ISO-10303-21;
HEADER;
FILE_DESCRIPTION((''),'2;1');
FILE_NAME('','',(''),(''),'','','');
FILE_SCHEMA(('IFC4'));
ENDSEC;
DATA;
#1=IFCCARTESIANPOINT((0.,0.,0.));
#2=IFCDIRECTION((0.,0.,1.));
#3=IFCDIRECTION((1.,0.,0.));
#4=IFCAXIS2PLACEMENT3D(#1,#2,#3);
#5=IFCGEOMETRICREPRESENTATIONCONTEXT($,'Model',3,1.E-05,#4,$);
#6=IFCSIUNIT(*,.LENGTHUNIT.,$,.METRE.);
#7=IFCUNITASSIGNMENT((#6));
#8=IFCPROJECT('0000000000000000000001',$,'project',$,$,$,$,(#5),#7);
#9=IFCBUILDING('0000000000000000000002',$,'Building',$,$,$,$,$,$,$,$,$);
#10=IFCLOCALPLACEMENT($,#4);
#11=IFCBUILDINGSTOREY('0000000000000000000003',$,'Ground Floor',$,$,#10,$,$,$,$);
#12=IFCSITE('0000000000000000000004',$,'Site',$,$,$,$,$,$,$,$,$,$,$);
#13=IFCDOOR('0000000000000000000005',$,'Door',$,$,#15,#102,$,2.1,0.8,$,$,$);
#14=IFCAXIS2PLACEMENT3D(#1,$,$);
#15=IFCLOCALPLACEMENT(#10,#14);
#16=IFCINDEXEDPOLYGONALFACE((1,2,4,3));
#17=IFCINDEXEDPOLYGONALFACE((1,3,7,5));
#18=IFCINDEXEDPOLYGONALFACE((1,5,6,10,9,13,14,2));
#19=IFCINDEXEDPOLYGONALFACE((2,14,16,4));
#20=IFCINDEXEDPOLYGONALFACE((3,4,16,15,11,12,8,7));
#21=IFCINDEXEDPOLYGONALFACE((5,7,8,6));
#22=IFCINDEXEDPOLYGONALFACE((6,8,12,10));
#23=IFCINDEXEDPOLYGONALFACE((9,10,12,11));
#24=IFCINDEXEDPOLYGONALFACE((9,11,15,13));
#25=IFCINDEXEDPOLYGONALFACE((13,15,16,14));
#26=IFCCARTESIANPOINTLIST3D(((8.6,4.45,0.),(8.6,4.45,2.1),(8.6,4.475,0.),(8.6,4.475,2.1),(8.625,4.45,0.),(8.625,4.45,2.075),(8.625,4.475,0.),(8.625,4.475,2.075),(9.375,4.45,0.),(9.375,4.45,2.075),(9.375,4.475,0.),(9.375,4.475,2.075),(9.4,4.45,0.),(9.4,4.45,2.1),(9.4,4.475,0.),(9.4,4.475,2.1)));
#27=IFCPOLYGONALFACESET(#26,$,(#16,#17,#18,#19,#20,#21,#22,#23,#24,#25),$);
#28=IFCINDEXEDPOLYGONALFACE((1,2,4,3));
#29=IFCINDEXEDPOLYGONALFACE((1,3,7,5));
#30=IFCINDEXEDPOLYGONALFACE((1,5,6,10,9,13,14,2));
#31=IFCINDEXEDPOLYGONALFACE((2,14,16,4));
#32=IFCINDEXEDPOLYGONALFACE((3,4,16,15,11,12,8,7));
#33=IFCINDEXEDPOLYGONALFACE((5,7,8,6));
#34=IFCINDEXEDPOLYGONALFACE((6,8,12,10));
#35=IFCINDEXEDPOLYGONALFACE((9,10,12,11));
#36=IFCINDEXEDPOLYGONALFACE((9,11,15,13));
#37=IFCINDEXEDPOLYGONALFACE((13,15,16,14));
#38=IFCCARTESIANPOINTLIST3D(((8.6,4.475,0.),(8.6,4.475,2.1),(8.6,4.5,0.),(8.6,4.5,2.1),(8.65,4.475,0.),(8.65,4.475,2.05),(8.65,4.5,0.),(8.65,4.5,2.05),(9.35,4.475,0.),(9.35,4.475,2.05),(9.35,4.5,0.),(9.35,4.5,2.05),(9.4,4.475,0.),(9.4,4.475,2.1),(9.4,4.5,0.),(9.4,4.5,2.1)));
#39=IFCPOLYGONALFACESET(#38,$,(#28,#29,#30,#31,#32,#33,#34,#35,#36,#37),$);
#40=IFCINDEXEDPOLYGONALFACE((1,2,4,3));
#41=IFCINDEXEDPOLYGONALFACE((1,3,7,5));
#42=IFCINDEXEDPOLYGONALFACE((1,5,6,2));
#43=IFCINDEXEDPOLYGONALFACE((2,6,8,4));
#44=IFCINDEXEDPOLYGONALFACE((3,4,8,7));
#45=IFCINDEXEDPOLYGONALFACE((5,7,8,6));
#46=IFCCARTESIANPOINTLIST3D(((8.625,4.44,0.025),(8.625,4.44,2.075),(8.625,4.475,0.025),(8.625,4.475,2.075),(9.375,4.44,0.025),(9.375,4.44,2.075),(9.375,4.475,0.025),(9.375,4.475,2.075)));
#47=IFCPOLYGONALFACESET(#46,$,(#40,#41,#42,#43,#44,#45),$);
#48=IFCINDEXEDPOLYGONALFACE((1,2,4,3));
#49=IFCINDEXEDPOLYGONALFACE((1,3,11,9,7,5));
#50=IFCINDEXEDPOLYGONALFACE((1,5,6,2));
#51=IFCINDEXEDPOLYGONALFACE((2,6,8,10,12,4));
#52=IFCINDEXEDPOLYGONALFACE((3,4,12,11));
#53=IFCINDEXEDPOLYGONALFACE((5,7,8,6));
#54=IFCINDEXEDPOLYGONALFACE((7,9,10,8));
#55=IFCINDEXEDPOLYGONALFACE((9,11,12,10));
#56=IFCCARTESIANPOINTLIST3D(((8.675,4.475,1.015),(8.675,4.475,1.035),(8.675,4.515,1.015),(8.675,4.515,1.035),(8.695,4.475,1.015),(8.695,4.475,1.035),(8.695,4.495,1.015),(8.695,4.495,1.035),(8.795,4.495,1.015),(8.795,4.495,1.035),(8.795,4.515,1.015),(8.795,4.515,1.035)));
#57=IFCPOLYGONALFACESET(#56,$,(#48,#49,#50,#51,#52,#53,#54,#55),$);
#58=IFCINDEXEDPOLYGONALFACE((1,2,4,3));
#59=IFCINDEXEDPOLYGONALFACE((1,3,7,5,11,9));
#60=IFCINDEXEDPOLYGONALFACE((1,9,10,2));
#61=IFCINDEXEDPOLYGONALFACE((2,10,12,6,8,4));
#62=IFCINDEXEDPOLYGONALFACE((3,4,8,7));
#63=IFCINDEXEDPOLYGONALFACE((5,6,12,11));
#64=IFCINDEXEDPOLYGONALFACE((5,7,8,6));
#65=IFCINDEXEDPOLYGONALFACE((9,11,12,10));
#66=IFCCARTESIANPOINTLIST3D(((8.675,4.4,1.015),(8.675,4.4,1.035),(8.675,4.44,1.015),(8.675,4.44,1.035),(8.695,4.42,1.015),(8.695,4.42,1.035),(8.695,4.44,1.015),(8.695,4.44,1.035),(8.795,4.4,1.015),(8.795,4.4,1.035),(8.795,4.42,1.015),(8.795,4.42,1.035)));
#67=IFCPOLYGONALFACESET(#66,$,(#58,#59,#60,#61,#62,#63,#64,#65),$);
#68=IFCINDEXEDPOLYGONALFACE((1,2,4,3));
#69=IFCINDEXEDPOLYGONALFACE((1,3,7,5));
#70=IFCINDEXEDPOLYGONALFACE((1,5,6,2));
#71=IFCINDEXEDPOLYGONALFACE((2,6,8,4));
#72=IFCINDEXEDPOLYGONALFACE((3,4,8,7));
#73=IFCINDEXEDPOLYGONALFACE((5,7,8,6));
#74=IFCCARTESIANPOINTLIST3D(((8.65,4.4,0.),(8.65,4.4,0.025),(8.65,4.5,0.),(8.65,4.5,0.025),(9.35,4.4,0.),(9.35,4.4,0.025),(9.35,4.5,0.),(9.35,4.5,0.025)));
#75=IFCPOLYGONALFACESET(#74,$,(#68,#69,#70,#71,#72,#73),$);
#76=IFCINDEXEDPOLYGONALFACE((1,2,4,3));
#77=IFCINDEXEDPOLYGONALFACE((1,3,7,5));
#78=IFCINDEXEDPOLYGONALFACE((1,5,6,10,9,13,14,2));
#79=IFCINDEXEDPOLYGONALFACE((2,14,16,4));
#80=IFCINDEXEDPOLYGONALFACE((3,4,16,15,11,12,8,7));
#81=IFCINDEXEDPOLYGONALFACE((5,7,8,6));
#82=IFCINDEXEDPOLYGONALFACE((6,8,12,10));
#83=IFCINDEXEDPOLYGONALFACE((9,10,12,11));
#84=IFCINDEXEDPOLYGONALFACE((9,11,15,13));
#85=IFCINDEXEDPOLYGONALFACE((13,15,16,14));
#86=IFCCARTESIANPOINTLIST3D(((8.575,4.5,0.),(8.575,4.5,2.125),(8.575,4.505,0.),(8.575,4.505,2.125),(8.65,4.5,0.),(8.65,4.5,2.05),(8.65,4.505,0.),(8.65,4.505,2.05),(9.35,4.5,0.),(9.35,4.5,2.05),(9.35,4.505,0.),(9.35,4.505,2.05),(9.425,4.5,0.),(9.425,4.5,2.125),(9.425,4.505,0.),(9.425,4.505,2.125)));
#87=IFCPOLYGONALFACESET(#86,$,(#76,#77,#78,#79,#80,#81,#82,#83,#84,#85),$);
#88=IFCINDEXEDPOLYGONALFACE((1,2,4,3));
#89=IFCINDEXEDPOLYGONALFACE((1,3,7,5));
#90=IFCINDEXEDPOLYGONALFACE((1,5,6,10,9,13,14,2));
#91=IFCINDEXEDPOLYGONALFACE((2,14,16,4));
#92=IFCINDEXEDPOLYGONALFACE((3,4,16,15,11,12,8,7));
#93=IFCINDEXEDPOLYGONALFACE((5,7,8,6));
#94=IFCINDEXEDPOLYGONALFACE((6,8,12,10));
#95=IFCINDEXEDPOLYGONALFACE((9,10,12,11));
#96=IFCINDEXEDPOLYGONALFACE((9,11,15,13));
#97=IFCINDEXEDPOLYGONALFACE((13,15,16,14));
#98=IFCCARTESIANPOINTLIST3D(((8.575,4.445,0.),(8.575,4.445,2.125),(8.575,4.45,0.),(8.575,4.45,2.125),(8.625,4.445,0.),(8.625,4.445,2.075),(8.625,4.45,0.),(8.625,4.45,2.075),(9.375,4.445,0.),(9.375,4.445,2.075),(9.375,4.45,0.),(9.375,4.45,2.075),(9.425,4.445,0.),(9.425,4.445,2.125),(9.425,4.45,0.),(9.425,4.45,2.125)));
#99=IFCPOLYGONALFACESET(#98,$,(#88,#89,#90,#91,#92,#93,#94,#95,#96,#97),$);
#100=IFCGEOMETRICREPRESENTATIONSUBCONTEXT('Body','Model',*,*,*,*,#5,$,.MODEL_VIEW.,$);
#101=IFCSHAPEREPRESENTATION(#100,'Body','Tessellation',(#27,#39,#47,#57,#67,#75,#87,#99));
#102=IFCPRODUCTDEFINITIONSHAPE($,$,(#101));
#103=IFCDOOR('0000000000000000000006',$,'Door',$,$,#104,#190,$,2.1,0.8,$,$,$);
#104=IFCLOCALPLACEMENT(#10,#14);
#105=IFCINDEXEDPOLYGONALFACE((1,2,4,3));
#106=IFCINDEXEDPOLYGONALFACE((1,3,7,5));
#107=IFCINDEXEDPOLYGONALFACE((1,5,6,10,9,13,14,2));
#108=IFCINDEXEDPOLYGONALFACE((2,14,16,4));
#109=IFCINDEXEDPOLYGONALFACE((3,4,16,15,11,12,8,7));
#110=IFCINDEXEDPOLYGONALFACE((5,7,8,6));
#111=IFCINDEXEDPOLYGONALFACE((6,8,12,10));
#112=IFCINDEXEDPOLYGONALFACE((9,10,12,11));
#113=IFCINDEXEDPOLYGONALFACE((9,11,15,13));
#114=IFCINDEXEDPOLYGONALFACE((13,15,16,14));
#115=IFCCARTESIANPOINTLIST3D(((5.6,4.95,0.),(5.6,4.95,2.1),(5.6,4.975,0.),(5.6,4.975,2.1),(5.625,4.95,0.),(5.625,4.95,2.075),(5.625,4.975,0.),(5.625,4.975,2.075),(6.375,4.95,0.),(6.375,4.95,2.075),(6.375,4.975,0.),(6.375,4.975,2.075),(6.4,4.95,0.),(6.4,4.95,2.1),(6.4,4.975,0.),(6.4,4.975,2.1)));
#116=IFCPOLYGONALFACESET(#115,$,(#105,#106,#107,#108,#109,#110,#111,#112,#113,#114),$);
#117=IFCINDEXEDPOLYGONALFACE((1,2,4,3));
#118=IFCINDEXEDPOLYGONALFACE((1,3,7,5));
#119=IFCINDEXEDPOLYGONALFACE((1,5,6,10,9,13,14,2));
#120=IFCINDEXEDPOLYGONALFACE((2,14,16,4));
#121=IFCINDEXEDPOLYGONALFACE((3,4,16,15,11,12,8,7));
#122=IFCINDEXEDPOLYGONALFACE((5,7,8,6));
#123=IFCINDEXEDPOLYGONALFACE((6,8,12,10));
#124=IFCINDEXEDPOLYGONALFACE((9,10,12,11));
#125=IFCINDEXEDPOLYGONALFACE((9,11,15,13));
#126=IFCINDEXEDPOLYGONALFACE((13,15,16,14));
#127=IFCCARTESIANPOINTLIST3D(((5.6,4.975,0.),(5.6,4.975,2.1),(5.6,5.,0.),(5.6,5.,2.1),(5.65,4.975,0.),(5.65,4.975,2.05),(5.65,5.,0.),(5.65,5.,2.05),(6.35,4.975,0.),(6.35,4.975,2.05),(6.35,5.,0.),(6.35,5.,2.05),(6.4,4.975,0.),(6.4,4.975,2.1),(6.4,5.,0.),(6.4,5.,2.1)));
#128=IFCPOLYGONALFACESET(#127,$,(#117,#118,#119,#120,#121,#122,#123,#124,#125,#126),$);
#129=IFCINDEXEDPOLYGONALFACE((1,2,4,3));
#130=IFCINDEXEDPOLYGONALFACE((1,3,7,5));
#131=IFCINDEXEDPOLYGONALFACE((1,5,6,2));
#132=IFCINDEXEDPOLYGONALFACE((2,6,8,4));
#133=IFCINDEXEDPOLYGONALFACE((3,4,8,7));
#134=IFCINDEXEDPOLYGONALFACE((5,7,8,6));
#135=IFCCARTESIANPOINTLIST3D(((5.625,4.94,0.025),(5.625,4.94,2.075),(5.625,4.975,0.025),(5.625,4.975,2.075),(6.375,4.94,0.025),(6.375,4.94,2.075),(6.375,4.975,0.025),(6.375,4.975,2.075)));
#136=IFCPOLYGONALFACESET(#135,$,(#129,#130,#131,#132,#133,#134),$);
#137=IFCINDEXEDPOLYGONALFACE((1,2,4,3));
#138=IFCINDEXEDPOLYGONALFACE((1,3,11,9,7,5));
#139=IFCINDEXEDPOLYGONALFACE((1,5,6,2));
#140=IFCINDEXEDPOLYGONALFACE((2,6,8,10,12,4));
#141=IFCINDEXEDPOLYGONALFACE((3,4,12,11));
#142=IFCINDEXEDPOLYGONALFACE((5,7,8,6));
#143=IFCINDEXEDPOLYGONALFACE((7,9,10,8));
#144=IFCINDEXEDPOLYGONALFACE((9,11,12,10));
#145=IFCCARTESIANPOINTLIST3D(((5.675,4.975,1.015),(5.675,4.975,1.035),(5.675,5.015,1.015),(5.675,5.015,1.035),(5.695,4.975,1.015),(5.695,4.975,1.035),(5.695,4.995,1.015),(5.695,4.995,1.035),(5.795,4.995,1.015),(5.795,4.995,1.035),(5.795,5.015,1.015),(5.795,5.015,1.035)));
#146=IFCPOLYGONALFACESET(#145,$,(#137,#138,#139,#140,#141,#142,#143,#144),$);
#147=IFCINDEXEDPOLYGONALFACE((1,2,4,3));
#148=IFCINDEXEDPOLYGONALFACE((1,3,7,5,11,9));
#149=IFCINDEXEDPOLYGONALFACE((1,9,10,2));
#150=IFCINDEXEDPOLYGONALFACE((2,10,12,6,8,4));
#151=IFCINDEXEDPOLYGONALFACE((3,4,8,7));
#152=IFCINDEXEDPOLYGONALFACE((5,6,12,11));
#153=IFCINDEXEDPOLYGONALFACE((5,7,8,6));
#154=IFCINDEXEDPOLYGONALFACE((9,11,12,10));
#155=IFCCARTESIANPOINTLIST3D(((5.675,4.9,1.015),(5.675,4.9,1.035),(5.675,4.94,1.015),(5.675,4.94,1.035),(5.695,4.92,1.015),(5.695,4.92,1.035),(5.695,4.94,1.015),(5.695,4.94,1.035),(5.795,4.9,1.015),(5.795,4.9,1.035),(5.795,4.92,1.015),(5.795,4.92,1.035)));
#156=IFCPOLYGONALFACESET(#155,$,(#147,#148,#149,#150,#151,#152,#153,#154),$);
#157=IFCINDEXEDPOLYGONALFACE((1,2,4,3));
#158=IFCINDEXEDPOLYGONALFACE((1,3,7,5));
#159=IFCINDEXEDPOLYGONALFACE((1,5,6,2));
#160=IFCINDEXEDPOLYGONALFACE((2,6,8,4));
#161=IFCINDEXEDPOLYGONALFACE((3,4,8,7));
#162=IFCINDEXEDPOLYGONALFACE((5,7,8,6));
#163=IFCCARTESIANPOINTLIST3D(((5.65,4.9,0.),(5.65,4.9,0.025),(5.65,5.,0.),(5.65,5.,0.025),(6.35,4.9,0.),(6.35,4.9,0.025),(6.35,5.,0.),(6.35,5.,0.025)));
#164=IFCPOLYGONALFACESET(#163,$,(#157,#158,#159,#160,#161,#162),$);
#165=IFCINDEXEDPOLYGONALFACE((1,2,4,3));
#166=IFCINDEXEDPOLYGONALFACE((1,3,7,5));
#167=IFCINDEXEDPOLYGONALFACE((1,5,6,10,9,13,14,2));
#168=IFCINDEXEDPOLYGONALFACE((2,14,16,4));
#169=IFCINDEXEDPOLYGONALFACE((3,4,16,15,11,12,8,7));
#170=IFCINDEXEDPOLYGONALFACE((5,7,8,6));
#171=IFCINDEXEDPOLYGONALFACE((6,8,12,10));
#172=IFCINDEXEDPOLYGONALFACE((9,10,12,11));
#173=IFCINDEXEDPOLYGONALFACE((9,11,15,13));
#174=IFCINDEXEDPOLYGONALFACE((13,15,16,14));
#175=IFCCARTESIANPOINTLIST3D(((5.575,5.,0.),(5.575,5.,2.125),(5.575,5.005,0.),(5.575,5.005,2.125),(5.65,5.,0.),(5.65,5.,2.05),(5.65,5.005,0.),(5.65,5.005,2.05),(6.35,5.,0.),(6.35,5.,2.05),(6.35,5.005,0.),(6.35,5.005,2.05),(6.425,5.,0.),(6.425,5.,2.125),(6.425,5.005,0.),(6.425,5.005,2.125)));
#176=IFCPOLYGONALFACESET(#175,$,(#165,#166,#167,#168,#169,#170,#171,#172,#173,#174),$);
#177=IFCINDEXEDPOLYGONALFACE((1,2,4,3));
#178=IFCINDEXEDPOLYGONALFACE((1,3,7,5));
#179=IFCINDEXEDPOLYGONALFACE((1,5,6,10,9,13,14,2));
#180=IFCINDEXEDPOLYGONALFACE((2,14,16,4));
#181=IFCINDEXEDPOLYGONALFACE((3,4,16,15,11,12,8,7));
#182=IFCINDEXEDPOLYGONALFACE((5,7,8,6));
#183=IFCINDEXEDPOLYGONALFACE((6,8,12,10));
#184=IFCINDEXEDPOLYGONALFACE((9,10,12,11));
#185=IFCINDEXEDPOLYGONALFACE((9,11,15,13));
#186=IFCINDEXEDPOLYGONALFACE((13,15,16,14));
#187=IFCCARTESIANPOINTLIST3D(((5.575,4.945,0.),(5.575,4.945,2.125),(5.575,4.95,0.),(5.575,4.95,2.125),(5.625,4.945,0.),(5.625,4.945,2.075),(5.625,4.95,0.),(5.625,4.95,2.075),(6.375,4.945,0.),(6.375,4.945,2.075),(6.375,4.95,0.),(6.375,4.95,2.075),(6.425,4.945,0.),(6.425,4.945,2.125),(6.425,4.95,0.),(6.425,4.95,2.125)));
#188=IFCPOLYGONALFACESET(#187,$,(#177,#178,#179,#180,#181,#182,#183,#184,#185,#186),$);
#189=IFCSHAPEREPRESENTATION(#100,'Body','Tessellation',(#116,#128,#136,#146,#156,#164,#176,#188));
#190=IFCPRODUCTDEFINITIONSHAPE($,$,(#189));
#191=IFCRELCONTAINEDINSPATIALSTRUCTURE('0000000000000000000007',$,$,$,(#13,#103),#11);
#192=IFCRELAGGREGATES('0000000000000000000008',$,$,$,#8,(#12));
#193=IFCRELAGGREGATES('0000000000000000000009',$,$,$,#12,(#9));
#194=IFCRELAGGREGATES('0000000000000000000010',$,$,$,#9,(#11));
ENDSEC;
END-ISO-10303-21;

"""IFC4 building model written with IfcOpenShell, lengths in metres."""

from ifc_helpers import new_model, si_unit, frame, origin_with_axes, place, context, subcontext, project, spatial, line, indexed_curve, outline, extrude, element, save


model = new_model("IFC4")

# Units and contexts
model_context = context("Model", 3, precision=1e-05, world=origin_with_axes())
body_context = subcontext(model_context, "Body", "Model", "MODEL_VIEW")
ifc_project = project(units=[si_unit("LENGTHUNIT", "METRE")], contexts=[model_context])

# Site, building, storey
site = spatial("IfcSite", under=ifc_project, Name="Site")
building = spatial("IfcBuilding", under=site, Name="Building")
storey_placement = place(None, origin_with_axes())
storey = spatial("IfcBuildingStorey", under=building, at=storey_placement, Name="Ground Floor")

# Doors
door_1_placement = place(storey_placement, frame((9.4, 4.5, 0.0), z_axis=(0.0, 0.0, 1.0), x_axis=(-1.0, 0.0, 0.0)))
element("IfcDoor", 1, at=door_1_placement, inside=storey, Name="Door", OverallHeight=2.1, OverallWidth=0.8, context=body_context, shape_type="SweptSolid", body=[
    extrude(outline(indexed_curve([(0.0, 0.0), (0.0, 2.1), (0.8, 2.1), (0.8, 0.0), (0.775, 0.0), (0.775, 2.075), (0.025, 2.075), (0.025, 0.0)], segments=[line(1, 2, 3, 4, 5, 6, 7, 8, 1)])), frame((0.0, 0.025, 0.0), z_axis=(0.0, -1.0, 0.0), x_axis=(1.0, 0.0, 0.0)), (0.0, 0.0, -1.0), 0.025),
    extrude(outline(indexed_curve([(0.0, 0.0), (0.0, 2.1), (0.8, 2.1), (0.8, 0.0), (0.75, 0.0), (0.75, 2.05), (0.05, 2.05), (0.05, 0.0)], segments=[line(1, 2, 3, 4, 5, 6, 7, 8, 1)])), frame((0.0, 0.0, 0.0), z_axis=(0.0, -1.0, 0.0), x_axis=(1.0, 0.0, 0.0)), (0.0, 0.0, -1.0), 0.025),
    extrude(outline(indexed_curve([(0.0, 0.0), (0.75, 0.0), (0.75, 0.035), (0.0, 0.035)], segments=[line(1, 2, 3, 4, 1)])), frame((0.025, 0.025, 0.025), z_axis=(0.0, 0.0, 1.0), x_axis=(1.0, 0.0, 0.0)), (0.0, 0.0, 1.0), 2.05),
    extrude(outline(indexed_curve([(0.0, 0.0), (0.0, -0.04), (-0.12, -0.04), (-0.12, -0.02), (-0.02, -0.02), (-0.02, 0.0)], segments=[line(1, 2, 3, 4, 5, 6, 1)])), frame((0.725, 0.025, 1.015), z_axis=(0.0, 0.0, 1.0), x_axis=(1.0, 0.0, 0.0)), (0.0, 0.0, 1.0), 0.02),
    extrude(outline(indexed_curve([(0.0, 0.0), (0.0, 0.04), (-0.12, 0.04), (-0.12, 0.02), (-0.02, 0.02), (-0.02, 0.0)], segments=[line(1, 2, 3, 4, 5, 6, 1)])), frame((0.725, 0.06, 1.015), z_axis=(0.0, 0.0, 1.0), x_axis=(1.0, 0.0, 0.0)), (0.0, 0.0, 1.0), 0.02),
    extrude(outline(indexed_curve([(0.0, 0.0), (0.7, 0.0), (0.7, 0.1), (0.0, 0.1)], segments=[line(1, 2, 3, 4, 1)])), frame((0.05, 0.0, 0.0), z_axis=(0.0, 0.0, 1.0), x_axis=(1.0, 0.0, 0.0)), (0.0, 0.0, 1.0), 0.025),
    extrude(outline(indexed_curve([(0.0, 0.0), (0.0, 2.125), (0.85, 2.125), (0.85, 0.0), (0.775, 0.0), (0.775, 2.05), (0.075, 2.05), (0.075, 0.0)], segments=[line(1, 2, 3, 4, 5, 6, 7, 8, 1)])), frame((-0.025, -0.005, 0.0), z_axis=(0.0, -1.0, 0.0), x_axis=(1.0, 0.0, 0.0)), (0.0, 0.0, -1.0), 0.005),
    extrude(outline(indexed_curve([(0.0, 0.0), (0.0, 2.125), (0.85, 2.125), (0.85, 0.0), (0.8, 0.0), (0.8, 2.075), (0.05, 2.075), (0.05, 0.0)], segments=[line(1, 2, 3, 4, 5, 6, 7, 8, 1)])), frame((-0.025, 0.05, 0.0), z_axis=(0.0, -1.0, 0.0), x_axis=(1.0, 0.0, 0.0)), (0.0, 0.0, -1.0), 0.005),
])
door_2_placement = place(storey_placement, frame((6.4, 5.0, 0.0), z_axis=(0.0, 0.0, 1.0), x_axis=(-1.0, 0.0, 0.0)))
element("IfcDoor", 2, at=door_2_placement, inside=storey, Name="Door", OverallHeight=2.1, OverallWidth=0.8, context=body_context, shape_type="SweptSolid", body=[
    extrude(outline(indexed_curve([(0.0, 0.0), (0.0, 2.1), (0.8, 2.1), (0.8, 0.0), (0.775, 0.0), (0.775, 2.075), (0.025, 2.075), (0.025, 0.0)], segments=[line(1, 2, 3, 4, 5, 6, 7, 8, 1)])), frame((0.0, 0.025, 0.0), z_axis=(0.0, -1.0, 0.0), x_axis=(1.0, 0.0, 0.0)), (0.0, 0.0, -1.0), 0.025),
    extrude(outline(indexed_curve([(0.0, 0.0), (0.0, 2.1), (0.8, 2.1), (0.8, 0.0), (0.75, 0.0), (0.75, 2.05), (0.05, 2.05), (0.05, 0.0)], segments=[line(1, 2, 3, 4, 5, 6, 7, 8, 1)])), frame((0.0, 0.0, 0.0), z_axis=(0.0, -1.0, 0.0), x_axis=(1.0, 0.0, 0.0)), (0.0, 0.0, -1.0), 0.025),
    extrude(outline(indexed_curve([(0.0, 0.0), (0.75, 0.0), (0.75, 0.035), (0.0, 0.035)], segments=[line(1, 2, 3, 4, 1)])), frame((0.025, 0.025, 0.025), z_axis=(0.0, 0.0, 1.0), x_axis=(1.0, 0.0, 0.0)), (0.0, 0.0, 1.0), 2.05),
    extrude(outline(indexed_curve([(0.0, 0.0), (0.0, -0.04), (-0.12, -0.04), (-0.12, -0.02), (-0.02, -0.02), (-0.02, 0.0)], segments=[line(1, 2, 3, 4, 5, 6, 1)])), frame((0.725, 0.025, 1.015), z_axis=(0.0, 0.0, 1.0), x_axis=(1.0, 0.0, 0.0)), (0.0, 0.0, 1.0), 0.02),
    extrude(outline(indexed_curve([(0.0, 0.0), (0.0, 0.04), (-0.12, 0.04), (-0.12, 0.02), (-0.02, 0.02), (-0.02, 0.0)], segments=[line(1, 2, 3, 4, 5, 6, 1)])), frame((0.725, 0.06, 1.015), z_axis=(0.0, 0.0, 1.0), x_axis=(1.0, 0.0, 0.0)), (0.0, 0.0, 1.0), 0.02),
    extrude(outline(indexed_curve([(0.0, 0.0), (0.7, 0.0), (0.7, 0.1), (0.0, 0.1)], segments=[line(1, 2, 3, 4, 1)])), frame((0.05, 0.0, 0.0), z_axis=(0.0, 0.0, 1.0), x_axis=(1.0, 0.0, 0.0)), (0.0, 0.0, 1.0), 0.025),
    extrude(outline(indexed_curve([(0.0, 0.0), (0.0, 2.125), (0.85, 2.125), (0.85, 0.0), (0.775, 0.0), (0.775, 2.05), (0.075, 2.05), (0.075, 0.0)], segments=[line(1, 2, 3, 4, 5, 6, 7, 8, 1)])), frame((-0.025, -0.005, 0.0), z_axis=(0.0, -1.0, 0.0), x_axis=(1.0, 0.0, 0.0)), (0.0, 0.0, -1.0), 0.005),
    extrude(outline(indexed_curve([(0.0, 0.0), (0.0, 2.125), (0.85, 2.125), (0.85, 0.0), (0.8, 0.0), (0.8, 2.075), (0.05, 2.075), (0.05, 0.0)], segments=[line(1, 2, 3, 4, 5, 6, 7, 8, 1)])), frame((-0.025, 0.05, 0.0), z_axis=(0.0, -1.0, 0.0), x_axis=(1.0, 0.0, 0.0)), (0.0, 0.0, -1.0), 0.005),
])

save(model, "model.ifc")
